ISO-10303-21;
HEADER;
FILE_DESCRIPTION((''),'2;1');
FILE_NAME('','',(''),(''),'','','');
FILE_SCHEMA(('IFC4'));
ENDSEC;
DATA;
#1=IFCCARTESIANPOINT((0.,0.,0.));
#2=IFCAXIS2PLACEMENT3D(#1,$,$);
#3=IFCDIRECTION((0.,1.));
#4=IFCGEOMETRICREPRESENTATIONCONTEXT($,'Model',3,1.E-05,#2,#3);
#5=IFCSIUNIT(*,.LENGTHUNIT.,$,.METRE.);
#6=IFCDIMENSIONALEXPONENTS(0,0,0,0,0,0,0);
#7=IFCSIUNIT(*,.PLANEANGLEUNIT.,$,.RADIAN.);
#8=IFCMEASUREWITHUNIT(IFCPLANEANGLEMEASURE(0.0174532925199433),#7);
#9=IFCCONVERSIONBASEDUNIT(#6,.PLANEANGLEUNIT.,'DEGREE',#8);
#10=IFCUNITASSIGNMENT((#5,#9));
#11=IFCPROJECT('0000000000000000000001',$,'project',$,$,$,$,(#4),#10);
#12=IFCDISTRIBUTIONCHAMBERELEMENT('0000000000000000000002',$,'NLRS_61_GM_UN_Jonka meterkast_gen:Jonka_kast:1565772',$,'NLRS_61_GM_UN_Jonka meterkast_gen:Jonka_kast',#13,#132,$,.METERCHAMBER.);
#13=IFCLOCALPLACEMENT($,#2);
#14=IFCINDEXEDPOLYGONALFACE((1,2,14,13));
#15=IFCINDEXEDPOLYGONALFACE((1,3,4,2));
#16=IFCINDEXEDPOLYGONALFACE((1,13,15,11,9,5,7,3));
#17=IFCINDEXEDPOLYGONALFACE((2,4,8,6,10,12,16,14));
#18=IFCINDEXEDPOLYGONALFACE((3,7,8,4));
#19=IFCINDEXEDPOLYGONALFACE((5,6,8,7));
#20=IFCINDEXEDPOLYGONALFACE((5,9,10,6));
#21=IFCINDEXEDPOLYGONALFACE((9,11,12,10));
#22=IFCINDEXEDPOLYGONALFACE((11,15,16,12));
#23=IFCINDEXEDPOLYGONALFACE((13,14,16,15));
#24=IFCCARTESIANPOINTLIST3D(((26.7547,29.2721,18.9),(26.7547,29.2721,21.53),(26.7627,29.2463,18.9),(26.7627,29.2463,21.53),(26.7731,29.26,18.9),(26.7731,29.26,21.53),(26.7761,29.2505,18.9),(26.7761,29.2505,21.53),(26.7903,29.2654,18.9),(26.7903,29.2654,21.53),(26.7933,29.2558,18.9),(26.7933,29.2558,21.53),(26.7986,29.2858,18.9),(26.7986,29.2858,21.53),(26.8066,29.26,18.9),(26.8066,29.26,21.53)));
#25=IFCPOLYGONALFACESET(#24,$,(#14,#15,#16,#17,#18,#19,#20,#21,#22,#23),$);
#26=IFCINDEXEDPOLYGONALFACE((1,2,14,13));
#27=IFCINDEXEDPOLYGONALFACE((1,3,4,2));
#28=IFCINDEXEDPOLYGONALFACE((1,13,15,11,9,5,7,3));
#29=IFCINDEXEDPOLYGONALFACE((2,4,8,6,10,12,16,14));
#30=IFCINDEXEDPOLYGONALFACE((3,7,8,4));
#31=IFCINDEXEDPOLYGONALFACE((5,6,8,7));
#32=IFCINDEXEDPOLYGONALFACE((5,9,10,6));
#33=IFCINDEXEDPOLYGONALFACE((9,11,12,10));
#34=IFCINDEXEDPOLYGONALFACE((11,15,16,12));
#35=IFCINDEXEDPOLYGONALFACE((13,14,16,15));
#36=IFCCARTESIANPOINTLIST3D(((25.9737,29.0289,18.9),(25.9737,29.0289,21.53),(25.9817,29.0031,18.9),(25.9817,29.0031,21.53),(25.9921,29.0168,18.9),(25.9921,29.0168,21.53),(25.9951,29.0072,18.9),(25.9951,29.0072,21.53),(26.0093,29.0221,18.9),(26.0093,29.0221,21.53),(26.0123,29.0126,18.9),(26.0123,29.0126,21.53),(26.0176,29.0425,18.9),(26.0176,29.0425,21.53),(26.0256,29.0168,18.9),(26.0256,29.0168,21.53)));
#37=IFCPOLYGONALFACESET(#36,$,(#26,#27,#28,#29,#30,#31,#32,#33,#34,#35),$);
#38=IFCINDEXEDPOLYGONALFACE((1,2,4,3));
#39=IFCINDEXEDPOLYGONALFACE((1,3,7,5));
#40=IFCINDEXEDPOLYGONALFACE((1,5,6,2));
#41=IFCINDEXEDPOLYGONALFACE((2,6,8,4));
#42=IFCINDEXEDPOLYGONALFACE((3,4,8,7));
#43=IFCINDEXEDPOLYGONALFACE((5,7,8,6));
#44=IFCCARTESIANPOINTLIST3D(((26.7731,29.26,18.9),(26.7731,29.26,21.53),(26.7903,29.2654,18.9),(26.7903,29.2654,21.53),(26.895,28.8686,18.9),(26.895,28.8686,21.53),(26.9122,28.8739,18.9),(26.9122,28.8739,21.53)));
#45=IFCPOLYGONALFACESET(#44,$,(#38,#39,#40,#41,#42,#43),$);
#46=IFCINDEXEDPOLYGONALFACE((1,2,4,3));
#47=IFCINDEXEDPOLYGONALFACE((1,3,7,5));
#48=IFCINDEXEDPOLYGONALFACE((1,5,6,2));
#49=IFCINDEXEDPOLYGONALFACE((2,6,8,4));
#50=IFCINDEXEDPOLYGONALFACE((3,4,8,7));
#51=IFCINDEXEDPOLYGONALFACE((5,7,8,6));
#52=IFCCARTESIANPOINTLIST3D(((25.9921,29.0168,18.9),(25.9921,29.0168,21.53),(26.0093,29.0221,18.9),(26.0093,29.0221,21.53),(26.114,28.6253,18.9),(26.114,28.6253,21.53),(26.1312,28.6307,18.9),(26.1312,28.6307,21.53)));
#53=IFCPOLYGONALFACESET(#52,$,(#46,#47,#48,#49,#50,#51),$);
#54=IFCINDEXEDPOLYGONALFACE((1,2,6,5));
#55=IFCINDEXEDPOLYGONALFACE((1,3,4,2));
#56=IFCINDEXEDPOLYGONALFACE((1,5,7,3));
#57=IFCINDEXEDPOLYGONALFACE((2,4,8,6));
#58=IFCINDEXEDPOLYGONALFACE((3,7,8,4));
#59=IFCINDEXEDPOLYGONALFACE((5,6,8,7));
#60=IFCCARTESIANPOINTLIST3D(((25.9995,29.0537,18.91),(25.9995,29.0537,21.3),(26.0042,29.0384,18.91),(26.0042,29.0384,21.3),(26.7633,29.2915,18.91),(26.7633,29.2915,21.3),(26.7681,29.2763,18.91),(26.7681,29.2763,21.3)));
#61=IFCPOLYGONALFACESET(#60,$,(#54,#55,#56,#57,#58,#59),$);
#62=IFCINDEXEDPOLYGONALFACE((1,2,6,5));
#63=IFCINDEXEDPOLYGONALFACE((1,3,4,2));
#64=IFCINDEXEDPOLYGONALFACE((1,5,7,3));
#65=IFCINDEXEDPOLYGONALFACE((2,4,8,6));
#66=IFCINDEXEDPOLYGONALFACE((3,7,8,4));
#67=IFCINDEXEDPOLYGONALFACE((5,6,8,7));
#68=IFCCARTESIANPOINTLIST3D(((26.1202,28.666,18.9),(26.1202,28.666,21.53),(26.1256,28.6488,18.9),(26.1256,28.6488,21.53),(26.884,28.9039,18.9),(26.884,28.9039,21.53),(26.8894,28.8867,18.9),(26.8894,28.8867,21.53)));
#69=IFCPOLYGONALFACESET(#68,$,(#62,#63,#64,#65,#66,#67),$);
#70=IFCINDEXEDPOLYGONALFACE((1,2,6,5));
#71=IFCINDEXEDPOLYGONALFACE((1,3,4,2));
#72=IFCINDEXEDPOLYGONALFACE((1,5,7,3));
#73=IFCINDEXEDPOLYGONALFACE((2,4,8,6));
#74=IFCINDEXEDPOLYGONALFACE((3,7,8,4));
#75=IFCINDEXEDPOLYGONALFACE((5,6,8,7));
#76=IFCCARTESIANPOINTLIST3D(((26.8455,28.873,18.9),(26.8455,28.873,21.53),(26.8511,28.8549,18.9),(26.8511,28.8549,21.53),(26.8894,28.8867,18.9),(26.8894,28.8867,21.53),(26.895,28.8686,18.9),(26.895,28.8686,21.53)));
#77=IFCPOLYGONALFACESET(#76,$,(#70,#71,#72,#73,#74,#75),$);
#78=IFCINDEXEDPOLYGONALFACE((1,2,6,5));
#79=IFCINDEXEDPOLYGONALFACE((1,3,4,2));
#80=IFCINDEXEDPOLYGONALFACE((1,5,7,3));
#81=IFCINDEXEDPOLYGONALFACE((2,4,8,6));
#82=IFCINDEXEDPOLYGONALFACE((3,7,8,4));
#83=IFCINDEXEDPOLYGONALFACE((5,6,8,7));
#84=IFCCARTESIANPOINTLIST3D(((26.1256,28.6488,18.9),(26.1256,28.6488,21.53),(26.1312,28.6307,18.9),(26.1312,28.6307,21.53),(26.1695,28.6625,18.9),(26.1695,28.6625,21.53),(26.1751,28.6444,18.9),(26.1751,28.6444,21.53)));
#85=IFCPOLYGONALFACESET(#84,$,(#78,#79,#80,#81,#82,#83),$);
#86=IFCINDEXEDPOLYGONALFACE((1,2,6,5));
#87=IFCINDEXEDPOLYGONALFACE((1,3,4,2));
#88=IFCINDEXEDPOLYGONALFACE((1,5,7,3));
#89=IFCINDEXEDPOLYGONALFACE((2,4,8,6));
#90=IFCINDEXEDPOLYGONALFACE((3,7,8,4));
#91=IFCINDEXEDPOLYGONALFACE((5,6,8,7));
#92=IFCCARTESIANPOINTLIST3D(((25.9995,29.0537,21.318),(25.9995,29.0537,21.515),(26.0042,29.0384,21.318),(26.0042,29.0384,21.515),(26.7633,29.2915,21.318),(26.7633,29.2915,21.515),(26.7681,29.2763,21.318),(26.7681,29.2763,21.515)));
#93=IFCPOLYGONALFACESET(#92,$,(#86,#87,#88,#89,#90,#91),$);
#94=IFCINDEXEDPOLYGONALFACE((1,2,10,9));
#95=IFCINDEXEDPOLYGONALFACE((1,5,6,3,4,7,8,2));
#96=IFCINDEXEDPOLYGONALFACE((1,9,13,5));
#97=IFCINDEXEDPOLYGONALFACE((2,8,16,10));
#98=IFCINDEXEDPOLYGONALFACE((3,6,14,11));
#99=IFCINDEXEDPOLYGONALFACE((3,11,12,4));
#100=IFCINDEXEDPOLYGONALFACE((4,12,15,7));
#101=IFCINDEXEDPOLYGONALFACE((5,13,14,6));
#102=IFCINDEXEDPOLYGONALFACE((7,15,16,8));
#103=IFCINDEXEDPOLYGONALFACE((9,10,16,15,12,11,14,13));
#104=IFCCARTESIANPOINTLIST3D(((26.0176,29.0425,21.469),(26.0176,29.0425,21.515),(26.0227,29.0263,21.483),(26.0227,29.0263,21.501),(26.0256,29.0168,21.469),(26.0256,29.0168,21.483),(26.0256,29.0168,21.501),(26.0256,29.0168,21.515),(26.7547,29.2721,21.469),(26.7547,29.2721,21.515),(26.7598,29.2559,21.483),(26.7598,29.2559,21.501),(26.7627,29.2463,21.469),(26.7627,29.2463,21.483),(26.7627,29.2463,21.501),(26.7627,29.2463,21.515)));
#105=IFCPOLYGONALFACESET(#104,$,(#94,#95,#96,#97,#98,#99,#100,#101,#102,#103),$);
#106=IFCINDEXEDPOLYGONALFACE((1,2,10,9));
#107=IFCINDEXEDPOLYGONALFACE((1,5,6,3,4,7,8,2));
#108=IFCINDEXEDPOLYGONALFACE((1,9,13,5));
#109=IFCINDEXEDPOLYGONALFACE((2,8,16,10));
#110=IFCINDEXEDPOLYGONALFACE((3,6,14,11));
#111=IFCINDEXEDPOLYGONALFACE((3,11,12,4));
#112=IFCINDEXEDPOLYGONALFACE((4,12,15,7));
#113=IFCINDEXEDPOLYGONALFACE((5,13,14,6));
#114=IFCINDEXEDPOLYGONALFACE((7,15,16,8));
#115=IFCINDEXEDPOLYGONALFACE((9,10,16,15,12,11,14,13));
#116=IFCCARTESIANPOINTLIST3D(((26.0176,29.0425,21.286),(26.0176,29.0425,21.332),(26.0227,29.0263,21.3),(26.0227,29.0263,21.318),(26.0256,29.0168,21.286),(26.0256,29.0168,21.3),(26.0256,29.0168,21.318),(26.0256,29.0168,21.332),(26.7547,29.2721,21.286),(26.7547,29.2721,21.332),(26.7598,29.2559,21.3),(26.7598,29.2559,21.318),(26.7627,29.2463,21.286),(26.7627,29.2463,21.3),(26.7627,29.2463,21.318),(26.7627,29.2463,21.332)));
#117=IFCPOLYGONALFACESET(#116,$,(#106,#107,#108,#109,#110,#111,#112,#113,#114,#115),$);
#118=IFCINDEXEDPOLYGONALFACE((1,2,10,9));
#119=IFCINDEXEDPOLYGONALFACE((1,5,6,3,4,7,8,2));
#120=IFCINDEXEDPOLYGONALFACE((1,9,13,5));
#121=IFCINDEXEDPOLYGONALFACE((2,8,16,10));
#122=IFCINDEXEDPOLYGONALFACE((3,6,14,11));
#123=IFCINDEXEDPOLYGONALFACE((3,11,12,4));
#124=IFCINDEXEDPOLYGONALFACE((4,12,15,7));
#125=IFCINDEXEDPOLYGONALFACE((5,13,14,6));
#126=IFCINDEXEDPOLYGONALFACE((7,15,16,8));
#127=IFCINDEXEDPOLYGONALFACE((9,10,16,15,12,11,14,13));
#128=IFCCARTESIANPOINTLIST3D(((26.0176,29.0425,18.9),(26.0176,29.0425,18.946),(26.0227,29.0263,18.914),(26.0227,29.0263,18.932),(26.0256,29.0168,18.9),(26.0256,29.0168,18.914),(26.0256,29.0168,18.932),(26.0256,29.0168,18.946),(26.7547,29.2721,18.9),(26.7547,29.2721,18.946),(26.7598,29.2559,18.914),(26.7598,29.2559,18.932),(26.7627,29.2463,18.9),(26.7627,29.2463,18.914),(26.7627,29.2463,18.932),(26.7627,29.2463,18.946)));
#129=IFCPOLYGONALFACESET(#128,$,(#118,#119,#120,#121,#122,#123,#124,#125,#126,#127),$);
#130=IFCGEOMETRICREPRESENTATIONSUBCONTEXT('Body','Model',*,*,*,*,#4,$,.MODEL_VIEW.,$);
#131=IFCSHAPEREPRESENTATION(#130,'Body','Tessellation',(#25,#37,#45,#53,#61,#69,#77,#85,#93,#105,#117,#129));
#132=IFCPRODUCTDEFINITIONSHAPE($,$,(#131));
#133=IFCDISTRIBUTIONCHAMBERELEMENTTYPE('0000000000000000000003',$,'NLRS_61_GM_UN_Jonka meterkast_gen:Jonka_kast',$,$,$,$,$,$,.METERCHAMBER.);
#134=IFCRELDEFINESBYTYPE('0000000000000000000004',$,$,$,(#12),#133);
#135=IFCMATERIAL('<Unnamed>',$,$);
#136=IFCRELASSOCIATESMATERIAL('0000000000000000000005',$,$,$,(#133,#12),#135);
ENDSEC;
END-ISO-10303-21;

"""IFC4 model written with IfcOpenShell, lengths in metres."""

from ifc_helpers import new_model, entity, si_unit, converted_unit, direction, frame, origin, place, context, subcontext, project, indexed_curve, outline, extrude, source, transform, mapped, material, type_object, type_shapes, element, save


model = new_model("IFC4")

# Units and contexts
model_context = context("Model", 3, precision=1e-05, world=origin(), true_north=direction((0.0, 1.0)))
body_context = subcontext(model_context, "Body", "Model", "MODEL_VIEW")
ifc_project = project(units=[si_unit("LENGTHUNIT", "METRE"), converted_unit("PLANEANGLEUNIT", "DEGREE", entity("IfcPlaneAngleMeasure", 0.0174532925199433), si_unit("PLANEANGLEUNIT", "RADIAN"), dimensions=[0, 0, 0, 0, 0, 0, 0])], contexts=[model_context])

# Distribution chamber element
ifc_material = material(Name="<Unnamed>")
distribution_chamber_element_type = type_object("IfcDistributionChamberElementType", Name="NLRS_61_GM_UN_Jonka meterkast_gen:Jonka_kast", PredefinedType="METERCHAMBER", material=ifc_material)
shared_shape_1 = source(origin(), body_context, "Body", "SweptSolid", [
    extrude(outline(indexed_curve([(-0.0093, -0.023), (0.0178, -0.023), (0.0178, 0.023), (-0.0093, 0.023), (-0.0093, 0.009), (0.0007, 0.009), (0.0007, -0.009), (-0.0093, -0.009), (-0.0093, -0.023)], self_intersect=False)), frame((-0.409, -0.4092, 0.0), z_axis=(0.0, 0.0, 1.0), x_axis=(0.0, -1.0, 0.0)), (0.0, 0.0, 1.0), 2.63),
    extrude(outline(indexed_curve([(-0.0093, -0.023), (0.0178, -0.023), (0.0178, 0.023), (-0.0093, 0.023), (-0.0093, 0.009), (0.0007, 0.009), (0.0007, -0.009), (-0.0093, -0.009), (-0.0093, -0.023)], self_intersect=False)), frame((0.409, -0.4092, 0.0), z_axis=(0.0, 0.0, 1.0), x_axis=(0.0, -1.0, 0.0)), (0.0, 0.0, 1.0), 2.63),
    extrude(outline(indexed_curve([(-0.205, -0.009), (0.205, -0.009), (0.205, 0.009), (-0.205, 0.009), (-0.205, -0.009)], self_intersect=False)), frame((-0.409, -0.205, 0.0), z_axis=(0.0, 0.0, 1.0), x_axis=(0.0, -1.0, 0.0)), (0.0, 0.0, 1.0), 2.63),
    extrude(outline(indexed_curve([(-0.205, -0.009), (0.205, -0.009), (0.205, 0.009), (-0.205, 0.009), (-0.205, -0.009)], self_intersect=False)), frame((0.409, -0.205, 0.0), z_axis=(0.0, 0.0, 1.0), x_axis=(0.0, -1.0, 0.0)), (0.0, 0.0, 1.0), 2.63),
    extrude(outline(indexed_curve([(-0.4, -0.008), (0.4, -0.008), (0.4, 0.008), (-0.4, 0.008), (-0.4, -0.008)], self_intersect=False)), frame((0.0, -0.435, 0.01), z_axis=(0.0, 0.0, 1.0), x_axis=(-1.0, 0.0, 0.0)), (0.0, 0.0, 1.0), 2.39),
    extrude(outline(indexed_curve([(-0.4, -0.009), (0.4, -0.009), (0.4, 0.009), (-0.4, 0.009), (-0.4, -0.009)], self_intersect=False)), frame((0.0, -0.028, 0.0), z_axis=(0.0, 0.0, 1.0), x_axis=(-1.0, 0.0, 0.0)), (0.0, 0.0, 1.0), 2.63),
    extrude(outline(indexed_curve([(-0.023, -0.0095), (0.023, -0.0095), (0.023, 0.0095), (-0.023, 0.0095), (-0.023, -0.0095)], self_intersect=False)), frame((-0.377, -0.0095, 0.0), z_axis=(0.0, 0.0, 1.0), x_axis=(-1.0, 0.0, 0.0)), (0.0, 0.0, 1.0), 2.63),
    extrude(outline(indexed_curve([(-0.023, -0.0095), (0.023, -0.0095), (0.023, 0.0095), (-0.023, 0.0095), (-0.023, -0.0095)], self_intersect=False)), frame((0.377, -0.0095, 0.0), z_axis=(0.0, 0.0, 1.0), x_axis=(-1.0, 0.0, 0.0)), (0.0, 0.0, 1.0), 2.63),
    extrude(outline(indexed_curve([(-0.4, -0.008), (0.4, -0.008), (0.4, 0.008), (-0.4, 0.008), (-0.4, -0.008)], self_intersect=False)), frame((0.0, -0.435, 2.418), z_axis=(0.0, 0.0, 1.0), x_axis=(-1.0, 0.0, 0.0)), (0.0, 0.0, 1.0), 0.197),
    extrude(outline(indexed_curve([(-0.023, -0.0178), (0.023, -0.0178), (0.023, 0.0093), (0.009, 0.0093), (0.009, -0.0007), (-0.009, -0.0007), (-0.009, 0.0093), (-0.023, 0.0093), (-0.023, -0.0178)], self_intersect=False)), frame((-0.386, -0.4092, 2.592), z_axis=(1.0, 0.0, 0.0), x_axis=(0.0, 0.0, -1.0)), (0.0, 0.0, 1.0), 0.772),
    extrude(outline(indexed_curve([(-0.023, -0.0178), (0.023, -0.0178), (0.023, 0.0093), (0.009, 0.0093), (0.009, -0.0007), (-0.009, -0.0007), (-0.009, 0.0093), (-0.023, 0.0093), (-0.023, -0.0178)], self_intersect=False)), frame((-0.386, -0.4092, 2.409), z_axis=(1.0, 0.0, 0.0), x_axis=(0.0, 0.0, -1.0)), (0.0, 0.0, 1.0), 0.772),
    extrude(outline(indexed_curve([(-0.023, -0.0178), (0.023, -0.0178), (0.023, 0.0093), (0.009, 0.0093), (0.009, -0.0007), (-0.009, -0.0007), (-0.009, 0.0093), (-0.023, 0.0093), (-0.023, -0.0178)], self_intersect=False)), frame((-0.386, -0.4092, 0.023), z_axis=(1.0, 0.0, 0.0), x_axis=(0.0, 0.0, -1.0)), (0.0, 0.0, 1.0), 0.772),
])
type_shapes(distribution_chamber_element_type, [shared_shape_1])
placement_1 = place(None, frame((13.1348, 11.9886, 0.0), z_axis=(0.0, 0.0, 1.0), x_axis=(0.954771, 0.297342, 0.0)))
placement_2 = place(placement_1, origin())
placement_3 = place(placement_2, frame((0.0, 0.0, 18.9)))
placement_4 = place(placement_3, origin())
distribution_chamber_element_1_placement = place(placement_4, frame((17.757, 12.025, 0.0), z_axis=(0.0, 0.0, 1.0), x_axis=(-1.0, 0.0, 0.0)))
element("IfcDistributionChamberElement", 1, at=distribution_chamber_element_1_placement, type_object=distribution_chamber_element_type, material=ifc_material, Name="NLRS_61_GM_UN_Jonka meterkast_gen:Jonka_kast:1565772", ObjectType="NLRS_61_GM_UN_Jonka meterkast_gen:Jonka_kast", PredefinedType="METERCHAMBER", context=body_context, shape_type="MappedRepresentation", body=[
    mapped(shared_shape_1, transform((0.0, 0.0, 0.0), scale=1.0)),
])

save(model, "model.ifc")
